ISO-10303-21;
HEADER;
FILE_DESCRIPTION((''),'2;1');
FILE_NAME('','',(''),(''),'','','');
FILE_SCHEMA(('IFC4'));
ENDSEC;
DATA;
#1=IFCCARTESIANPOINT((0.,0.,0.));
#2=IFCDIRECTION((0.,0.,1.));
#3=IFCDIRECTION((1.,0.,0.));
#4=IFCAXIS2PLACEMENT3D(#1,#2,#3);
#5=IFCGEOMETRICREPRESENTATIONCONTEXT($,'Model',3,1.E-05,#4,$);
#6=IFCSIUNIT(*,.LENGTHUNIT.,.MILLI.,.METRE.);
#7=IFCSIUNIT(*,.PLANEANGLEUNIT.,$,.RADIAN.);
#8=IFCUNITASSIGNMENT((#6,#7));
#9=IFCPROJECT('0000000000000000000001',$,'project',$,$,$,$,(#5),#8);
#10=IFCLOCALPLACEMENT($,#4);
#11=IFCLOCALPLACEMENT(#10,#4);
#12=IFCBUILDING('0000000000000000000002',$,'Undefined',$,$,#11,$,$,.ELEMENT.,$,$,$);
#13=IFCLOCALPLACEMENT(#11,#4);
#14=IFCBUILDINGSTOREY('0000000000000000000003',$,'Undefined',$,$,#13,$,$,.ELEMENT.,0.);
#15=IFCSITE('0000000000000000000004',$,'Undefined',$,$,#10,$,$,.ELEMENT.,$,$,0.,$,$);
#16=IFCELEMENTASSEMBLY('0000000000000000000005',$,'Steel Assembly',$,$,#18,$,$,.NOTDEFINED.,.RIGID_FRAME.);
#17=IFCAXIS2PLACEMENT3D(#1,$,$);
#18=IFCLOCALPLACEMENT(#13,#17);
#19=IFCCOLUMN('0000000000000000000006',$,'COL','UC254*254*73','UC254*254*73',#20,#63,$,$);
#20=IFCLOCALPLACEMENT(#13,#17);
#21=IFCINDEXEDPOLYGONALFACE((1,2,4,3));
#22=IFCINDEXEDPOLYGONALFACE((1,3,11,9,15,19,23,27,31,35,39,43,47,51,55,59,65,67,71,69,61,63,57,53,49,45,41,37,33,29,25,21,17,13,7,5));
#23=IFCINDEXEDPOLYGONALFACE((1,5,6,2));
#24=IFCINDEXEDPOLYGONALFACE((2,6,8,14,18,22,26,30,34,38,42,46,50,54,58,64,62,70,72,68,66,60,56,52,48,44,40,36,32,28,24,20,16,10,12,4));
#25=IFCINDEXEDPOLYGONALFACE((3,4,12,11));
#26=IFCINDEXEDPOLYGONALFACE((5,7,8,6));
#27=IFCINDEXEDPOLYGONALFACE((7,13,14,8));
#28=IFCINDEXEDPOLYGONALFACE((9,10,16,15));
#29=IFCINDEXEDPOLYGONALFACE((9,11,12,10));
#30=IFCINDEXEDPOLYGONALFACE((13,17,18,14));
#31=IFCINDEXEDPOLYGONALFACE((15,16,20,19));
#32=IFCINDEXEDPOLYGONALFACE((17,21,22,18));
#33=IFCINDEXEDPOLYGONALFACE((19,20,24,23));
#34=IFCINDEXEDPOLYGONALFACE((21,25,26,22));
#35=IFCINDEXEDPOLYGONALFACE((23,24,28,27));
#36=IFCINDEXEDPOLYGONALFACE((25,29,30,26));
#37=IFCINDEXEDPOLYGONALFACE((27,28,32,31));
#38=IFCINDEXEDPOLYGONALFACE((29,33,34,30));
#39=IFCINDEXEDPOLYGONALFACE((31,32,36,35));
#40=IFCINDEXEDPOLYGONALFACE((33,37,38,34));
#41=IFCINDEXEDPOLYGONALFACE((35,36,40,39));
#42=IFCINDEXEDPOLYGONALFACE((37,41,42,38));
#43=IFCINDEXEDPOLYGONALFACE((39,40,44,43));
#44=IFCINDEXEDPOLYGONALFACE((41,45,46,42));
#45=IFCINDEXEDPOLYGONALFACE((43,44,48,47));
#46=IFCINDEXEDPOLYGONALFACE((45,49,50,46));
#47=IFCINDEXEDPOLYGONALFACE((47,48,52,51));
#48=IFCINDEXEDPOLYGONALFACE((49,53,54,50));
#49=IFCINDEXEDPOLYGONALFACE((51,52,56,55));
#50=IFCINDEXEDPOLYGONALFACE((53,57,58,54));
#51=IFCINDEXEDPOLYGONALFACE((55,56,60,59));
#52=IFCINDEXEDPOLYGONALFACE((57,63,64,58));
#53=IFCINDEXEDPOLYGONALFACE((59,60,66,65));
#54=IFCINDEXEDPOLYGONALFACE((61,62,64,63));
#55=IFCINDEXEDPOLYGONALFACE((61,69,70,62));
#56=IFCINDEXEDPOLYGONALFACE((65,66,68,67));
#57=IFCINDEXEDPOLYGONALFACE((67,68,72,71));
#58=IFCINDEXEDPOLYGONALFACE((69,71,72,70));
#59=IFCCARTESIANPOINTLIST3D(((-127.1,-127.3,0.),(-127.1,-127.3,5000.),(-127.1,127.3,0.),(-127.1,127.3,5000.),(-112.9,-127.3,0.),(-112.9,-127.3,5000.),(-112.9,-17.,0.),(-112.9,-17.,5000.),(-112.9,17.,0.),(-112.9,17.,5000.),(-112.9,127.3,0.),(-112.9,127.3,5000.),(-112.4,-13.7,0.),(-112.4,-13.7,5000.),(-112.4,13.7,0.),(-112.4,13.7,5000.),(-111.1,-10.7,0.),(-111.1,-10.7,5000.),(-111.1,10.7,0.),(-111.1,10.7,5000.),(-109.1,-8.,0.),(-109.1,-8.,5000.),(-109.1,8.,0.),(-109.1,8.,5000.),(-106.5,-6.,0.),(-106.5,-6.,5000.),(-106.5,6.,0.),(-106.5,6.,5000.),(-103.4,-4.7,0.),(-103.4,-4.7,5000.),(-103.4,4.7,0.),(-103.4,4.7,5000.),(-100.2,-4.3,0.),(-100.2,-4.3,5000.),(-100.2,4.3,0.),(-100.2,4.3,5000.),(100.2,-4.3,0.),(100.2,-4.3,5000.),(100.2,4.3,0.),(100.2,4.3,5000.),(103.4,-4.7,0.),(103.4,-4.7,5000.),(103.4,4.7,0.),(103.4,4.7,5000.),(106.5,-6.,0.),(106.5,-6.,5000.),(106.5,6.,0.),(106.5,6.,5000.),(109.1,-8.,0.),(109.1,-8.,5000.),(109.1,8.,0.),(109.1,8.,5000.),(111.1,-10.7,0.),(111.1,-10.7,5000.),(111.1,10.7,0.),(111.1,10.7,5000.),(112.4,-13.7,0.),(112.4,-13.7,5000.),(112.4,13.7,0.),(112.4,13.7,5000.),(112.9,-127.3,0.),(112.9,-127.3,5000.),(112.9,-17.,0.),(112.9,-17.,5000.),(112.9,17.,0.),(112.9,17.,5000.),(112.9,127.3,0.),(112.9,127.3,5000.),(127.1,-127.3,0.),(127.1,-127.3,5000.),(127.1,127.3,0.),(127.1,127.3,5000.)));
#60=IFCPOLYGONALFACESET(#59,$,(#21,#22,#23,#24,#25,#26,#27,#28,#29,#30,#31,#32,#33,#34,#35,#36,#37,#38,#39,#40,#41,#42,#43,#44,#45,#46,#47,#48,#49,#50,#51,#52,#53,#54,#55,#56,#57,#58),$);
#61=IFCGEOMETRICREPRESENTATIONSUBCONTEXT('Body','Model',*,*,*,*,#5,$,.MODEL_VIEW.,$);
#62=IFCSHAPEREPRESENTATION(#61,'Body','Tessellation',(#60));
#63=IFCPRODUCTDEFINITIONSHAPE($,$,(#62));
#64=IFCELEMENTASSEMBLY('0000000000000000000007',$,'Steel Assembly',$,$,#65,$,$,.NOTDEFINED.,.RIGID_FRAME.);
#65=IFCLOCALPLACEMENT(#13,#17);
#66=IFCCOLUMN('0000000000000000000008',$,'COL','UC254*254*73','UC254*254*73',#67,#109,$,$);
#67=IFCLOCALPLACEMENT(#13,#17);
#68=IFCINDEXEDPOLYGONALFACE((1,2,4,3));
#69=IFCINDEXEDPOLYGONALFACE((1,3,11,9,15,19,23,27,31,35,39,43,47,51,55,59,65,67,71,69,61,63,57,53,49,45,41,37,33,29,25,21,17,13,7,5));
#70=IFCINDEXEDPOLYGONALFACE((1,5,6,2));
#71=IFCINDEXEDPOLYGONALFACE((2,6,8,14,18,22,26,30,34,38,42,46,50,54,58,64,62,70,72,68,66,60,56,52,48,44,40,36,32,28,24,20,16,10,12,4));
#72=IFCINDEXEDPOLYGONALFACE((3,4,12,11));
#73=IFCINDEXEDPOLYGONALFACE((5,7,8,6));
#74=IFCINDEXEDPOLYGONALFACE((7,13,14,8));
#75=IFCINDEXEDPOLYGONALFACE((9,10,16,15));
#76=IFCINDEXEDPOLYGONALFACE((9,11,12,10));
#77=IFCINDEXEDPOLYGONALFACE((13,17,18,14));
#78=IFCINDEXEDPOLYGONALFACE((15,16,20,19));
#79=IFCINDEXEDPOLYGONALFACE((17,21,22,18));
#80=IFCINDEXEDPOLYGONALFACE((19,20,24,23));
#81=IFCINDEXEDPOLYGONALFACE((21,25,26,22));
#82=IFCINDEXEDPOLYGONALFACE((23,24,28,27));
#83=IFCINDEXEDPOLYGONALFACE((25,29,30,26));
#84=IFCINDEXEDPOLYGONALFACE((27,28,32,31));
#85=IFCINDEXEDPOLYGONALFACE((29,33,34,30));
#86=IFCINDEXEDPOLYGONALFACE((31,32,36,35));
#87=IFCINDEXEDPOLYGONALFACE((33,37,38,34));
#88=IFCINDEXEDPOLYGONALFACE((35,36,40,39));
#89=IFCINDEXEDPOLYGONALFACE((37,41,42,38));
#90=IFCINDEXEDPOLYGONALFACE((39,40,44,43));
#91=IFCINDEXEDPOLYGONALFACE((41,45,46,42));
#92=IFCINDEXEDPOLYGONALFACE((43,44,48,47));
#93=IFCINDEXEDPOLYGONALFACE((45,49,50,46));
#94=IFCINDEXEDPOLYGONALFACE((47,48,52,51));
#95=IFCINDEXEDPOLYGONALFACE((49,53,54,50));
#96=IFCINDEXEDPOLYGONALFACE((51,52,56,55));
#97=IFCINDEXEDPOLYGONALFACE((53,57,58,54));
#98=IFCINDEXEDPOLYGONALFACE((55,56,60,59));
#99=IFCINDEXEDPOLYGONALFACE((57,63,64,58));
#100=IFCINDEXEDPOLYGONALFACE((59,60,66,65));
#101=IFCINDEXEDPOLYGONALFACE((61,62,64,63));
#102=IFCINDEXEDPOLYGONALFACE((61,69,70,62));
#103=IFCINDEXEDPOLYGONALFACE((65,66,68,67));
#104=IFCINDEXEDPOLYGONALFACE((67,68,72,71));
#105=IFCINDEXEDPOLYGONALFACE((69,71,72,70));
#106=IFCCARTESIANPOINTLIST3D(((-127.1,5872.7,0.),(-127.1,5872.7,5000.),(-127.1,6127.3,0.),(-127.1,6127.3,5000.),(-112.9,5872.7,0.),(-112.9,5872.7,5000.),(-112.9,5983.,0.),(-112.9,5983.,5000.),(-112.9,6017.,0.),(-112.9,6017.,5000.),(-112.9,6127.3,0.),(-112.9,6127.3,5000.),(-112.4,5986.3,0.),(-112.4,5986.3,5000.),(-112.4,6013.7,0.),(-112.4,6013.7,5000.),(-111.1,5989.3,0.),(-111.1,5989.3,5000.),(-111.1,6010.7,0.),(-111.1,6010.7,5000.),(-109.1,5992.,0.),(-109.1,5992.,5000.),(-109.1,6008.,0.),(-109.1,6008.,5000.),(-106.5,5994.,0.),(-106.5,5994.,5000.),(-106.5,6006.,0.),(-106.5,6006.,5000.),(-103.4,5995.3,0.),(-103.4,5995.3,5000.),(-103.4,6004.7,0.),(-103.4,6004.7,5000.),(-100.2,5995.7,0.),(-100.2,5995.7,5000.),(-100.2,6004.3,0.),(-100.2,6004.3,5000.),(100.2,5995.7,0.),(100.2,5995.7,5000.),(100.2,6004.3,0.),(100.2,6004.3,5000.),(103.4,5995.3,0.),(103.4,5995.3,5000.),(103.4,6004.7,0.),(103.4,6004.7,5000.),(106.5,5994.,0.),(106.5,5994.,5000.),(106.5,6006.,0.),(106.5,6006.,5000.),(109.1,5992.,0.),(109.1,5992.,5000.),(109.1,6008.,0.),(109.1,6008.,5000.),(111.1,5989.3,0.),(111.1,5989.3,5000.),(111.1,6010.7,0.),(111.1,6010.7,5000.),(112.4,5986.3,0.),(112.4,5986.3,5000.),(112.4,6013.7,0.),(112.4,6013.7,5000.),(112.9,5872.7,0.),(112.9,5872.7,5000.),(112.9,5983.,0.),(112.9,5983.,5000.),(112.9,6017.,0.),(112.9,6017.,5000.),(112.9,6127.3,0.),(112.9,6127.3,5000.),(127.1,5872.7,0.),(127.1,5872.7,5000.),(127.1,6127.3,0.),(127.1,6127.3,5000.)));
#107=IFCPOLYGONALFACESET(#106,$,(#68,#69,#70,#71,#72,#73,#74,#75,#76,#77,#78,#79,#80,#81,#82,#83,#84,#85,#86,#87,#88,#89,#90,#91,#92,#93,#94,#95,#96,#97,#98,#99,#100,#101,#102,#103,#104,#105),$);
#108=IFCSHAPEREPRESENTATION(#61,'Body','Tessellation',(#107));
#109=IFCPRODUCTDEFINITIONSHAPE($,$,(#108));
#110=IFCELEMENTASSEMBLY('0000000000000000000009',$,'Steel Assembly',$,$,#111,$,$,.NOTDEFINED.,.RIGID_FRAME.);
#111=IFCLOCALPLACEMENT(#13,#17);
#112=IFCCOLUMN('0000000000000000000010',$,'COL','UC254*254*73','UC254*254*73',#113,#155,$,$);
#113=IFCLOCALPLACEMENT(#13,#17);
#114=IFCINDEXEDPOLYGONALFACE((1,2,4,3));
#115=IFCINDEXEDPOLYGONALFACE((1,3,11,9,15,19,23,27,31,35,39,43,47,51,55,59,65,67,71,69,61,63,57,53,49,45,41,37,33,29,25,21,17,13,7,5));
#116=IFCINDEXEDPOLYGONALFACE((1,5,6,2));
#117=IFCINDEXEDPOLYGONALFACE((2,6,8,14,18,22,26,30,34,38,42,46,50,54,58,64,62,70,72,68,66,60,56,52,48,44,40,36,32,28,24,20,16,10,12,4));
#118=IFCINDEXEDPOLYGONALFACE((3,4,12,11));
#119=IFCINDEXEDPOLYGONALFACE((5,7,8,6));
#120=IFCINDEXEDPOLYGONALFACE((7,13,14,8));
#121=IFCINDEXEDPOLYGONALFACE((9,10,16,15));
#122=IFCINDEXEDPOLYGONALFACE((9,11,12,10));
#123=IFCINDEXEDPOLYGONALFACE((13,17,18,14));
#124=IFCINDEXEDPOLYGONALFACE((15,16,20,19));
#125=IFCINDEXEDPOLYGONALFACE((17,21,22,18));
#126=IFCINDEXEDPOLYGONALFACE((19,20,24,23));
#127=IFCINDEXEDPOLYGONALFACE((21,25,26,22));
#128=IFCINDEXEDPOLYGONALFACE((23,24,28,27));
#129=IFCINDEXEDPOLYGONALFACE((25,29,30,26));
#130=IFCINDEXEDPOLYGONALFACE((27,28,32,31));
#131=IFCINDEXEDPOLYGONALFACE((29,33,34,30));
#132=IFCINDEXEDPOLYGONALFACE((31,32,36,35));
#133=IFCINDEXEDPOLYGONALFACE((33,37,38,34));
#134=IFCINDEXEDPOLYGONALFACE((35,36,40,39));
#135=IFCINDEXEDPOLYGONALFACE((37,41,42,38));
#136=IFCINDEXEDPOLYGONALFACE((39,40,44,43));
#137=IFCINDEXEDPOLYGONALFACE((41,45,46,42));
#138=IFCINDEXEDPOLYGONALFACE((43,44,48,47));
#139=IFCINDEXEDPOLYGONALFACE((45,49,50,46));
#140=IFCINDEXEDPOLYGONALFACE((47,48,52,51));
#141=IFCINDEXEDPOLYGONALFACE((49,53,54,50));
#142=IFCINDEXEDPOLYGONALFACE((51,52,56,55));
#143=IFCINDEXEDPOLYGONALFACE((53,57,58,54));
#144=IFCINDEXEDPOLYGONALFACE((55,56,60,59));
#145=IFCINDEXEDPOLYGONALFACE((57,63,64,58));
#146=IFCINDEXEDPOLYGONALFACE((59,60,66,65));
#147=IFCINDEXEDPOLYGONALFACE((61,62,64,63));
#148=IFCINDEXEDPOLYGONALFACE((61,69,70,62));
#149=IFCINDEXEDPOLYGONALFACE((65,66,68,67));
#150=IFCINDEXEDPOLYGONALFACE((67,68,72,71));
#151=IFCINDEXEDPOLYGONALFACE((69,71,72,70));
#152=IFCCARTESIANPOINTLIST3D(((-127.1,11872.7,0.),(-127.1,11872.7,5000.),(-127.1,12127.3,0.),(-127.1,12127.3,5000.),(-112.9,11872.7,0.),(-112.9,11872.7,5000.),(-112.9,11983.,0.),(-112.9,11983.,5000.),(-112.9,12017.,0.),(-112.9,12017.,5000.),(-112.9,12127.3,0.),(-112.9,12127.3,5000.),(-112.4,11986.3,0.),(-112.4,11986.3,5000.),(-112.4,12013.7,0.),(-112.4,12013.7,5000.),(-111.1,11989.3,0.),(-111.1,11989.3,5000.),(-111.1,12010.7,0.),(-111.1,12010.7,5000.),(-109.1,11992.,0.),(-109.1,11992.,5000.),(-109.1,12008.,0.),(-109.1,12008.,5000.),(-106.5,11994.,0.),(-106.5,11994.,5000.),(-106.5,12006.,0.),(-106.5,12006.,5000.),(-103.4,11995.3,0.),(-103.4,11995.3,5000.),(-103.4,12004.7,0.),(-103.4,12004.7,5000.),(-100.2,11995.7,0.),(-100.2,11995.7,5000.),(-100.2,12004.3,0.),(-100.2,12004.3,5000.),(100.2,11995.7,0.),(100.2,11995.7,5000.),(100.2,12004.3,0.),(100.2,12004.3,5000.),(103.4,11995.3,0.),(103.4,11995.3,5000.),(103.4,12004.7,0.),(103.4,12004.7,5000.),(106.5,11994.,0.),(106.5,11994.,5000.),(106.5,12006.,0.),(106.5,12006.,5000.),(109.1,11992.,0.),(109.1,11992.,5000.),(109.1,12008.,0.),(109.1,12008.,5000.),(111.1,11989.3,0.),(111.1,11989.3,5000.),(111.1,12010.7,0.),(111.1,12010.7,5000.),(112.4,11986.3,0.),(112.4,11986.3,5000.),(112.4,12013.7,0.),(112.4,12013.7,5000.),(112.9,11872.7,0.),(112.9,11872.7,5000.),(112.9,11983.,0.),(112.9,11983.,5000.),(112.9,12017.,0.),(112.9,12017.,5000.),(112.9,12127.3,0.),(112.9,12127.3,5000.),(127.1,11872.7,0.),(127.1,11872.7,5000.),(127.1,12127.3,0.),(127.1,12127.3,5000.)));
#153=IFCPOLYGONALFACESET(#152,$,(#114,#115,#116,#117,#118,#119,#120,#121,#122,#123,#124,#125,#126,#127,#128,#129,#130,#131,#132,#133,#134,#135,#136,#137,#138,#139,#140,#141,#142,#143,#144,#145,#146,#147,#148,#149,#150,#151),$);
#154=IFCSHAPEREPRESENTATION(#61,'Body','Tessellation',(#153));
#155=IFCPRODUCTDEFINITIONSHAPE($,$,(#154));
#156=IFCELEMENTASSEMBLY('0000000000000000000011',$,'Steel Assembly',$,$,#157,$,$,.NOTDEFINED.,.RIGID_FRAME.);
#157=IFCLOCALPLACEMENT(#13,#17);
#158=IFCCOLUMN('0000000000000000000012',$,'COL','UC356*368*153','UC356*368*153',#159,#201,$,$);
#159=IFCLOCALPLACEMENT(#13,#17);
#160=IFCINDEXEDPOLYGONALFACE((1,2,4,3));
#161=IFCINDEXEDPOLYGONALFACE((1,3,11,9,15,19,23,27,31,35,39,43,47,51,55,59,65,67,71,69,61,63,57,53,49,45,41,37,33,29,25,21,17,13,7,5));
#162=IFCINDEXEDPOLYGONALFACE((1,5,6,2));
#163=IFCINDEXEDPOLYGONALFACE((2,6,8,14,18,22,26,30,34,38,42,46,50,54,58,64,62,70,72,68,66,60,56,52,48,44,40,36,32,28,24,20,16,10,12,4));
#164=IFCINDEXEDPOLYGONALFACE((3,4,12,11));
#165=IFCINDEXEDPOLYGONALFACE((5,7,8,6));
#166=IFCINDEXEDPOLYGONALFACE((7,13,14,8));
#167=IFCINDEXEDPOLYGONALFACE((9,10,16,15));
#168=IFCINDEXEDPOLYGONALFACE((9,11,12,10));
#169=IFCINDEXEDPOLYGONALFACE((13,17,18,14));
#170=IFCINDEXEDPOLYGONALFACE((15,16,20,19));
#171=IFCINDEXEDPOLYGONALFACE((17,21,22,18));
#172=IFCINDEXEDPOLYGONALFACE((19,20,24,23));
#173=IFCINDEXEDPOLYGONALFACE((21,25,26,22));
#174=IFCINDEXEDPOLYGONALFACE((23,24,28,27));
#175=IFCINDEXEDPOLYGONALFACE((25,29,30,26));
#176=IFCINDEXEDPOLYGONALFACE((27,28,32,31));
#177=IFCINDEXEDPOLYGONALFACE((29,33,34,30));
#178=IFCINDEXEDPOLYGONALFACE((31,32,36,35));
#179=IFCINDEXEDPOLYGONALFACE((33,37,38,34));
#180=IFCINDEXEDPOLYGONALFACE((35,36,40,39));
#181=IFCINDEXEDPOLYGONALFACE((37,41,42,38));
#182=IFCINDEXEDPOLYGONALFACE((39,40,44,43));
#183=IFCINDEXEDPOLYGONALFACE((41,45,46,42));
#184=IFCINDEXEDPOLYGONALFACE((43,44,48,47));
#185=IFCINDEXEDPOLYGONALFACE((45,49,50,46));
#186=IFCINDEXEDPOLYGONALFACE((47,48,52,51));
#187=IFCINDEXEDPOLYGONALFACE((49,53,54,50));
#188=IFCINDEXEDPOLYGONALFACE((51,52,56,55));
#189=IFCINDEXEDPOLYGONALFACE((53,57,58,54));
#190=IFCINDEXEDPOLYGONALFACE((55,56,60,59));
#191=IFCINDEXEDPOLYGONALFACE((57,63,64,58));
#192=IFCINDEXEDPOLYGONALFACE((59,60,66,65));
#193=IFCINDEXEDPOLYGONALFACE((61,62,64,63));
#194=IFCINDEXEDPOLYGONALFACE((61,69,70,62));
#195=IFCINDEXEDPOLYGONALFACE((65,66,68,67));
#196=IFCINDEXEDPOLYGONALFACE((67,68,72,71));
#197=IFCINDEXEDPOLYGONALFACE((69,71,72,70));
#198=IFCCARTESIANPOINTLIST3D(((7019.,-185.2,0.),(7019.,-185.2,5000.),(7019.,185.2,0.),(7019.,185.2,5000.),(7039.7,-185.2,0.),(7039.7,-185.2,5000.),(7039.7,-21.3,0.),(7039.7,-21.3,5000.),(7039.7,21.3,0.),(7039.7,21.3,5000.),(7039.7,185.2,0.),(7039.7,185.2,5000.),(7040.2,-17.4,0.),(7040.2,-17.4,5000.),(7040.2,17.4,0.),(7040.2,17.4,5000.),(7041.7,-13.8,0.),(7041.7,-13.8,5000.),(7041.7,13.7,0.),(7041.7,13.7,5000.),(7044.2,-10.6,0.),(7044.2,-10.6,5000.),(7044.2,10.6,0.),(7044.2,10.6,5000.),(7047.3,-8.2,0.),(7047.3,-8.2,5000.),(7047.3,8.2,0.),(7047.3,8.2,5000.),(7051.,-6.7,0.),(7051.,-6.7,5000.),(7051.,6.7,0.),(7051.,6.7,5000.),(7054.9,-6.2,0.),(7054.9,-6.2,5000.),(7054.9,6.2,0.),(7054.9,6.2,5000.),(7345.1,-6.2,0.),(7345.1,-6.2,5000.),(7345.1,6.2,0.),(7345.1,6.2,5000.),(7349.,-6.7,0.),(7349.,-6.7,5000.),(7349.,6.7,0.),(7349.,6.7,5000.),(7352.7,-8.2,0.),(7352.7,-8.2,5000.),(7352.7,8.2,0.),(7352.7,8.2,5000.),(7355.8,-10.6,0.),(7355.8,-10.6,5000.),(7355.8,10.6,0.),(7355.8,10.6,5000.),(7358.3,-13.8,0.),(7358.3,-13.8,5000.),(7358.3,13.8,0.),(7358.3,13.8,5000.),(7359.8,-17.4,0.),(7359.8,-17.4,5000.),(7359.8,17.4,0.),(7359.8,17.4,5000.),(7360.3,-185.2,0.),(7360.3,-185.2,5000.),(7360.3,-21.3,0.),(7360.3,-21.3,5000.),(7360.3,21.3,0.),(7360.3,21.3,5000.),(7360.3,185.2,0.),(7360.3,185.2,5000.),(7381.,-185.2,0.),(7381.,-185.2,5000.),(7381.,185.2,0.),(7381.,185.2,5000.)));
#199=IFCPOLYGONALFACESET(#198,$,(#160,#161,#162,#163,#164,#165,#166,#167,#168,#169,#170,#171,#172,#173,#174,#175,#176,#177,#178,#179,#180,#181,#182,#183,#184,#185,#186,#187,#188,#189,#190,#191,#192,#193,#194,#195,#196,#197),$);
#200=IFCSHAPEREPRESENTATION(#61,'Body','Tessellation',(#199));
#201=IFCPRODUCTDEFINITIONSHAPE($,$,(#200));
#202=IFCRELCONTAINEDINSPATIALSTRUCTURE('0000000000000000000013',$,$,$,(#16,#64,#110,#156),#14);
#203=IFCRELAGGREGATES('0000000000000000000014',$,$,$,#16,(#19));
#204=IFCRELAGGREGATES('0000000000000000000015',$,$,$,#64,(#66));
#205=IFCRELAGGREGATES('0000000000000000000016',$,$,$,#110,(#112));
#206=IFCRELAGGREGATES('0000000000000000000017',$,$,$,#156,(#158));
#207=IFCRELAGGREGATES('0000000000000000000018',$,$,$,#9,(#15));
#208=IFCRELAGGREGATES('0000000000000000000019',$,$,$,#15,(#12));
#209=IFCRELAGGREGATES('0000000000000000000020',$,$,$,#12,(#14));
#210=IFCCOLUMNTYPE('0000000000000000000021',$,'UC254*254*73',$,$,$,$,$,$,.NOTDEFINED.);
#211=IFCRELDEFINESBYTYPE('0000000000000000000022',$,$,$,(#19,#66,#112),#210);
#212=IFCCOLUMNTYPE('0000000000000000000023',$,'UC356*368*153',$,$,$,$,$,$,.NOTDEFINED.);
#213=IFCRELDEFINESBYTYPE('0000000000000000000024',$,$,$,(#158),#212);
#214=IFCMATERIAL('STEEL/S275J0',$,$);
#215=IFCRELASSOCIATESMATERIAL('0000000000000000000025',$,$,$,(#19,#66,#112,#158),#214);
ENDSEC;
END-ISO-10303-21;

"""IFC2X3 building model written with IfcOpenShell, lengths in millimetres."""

from ifc_helpers import new_model, si_unit, frame, origin_with_axes, origin_2d_with_axis, place, context, subcontext, project, spatial, i_section, extrude, material, type_object, element, aggregate, save


model = new_model("IFC2X3")

# Units and contexts
model_context = context("Model", 3, precision=1e-05, world=origin_with_axes())
body_context = subcontext(model_context, "Body", "Model", "MODEL_VIEW")
ifc_project = project(units=[si_unit("LENGTHUNIT", "METRE", prefix="MILLI"), si_unit("PLANEANGLEUNIT", "RADIAN")], contexts=[model_context])

# Site, building, storey
site_placement = place(None, origin_with_axes())
site = spatial("IfcSite", under=ifc_project, at=site_placement, Name="Undefined", CompositionType="ELEMENT", RefElevation=0.0)
building_placement = place(site_placement, origin_with_axes())
building = spatial("IfcBuilding", under=site, at=building_placement, Name="Undefined", CompositionType="ELEMENT")
storey_placement = place(building_placement, origin_with_axes())
storey = spatial("IfcBuildingStorey", under=building, at=storey_placement, Name="Undefined", CompositionType="ELEMENT", Elevation=0.0)

# Element assemblies, columns
assembly_1_placement = place(storey_placement, origin_with_axes())
assembly_1 = element("IfcElementAssembly", 1, at=assembly_1_placement, inside=storey, Name="Steel Assembly", AssemblyPlace="NOTDEFINED", PredefinedType="RIGID_FRAME")
ifc_material = material(Name="STEEL/S275J0")
column_type_1 = type_object("IfcColumnType", Name="UC254*254*73", PredefinedType="NOTDEFINED")
column_1_placement = place(assembly_1_placement, origin_with_axes())
column_1 = element("IfcColumn", 2, at=column_1_placement, type_object=column_type_1, material=ifc_material, Name="COL", Description="UC254*254*73", ObjectType="UC254*254*73", context=body_context, shape_type="SweptSolid", body=[
    extrude(i_section(OverallWidth=254.6, OverallDepth=254.1, WebThickness=8.6, FlangeThickness=14.2, FilletRadius=12.7, at=origin_2d_with_axis()), frame((0.0, 0.0, 5000.0), z_axis=(0.0, 0.0, -1.0), x_axis=(0.0, -1.0, 0.0)), (0.0, 0.0, 1.0), 5000.0),
])
aggregate(assembly_1, [column_1])
assembly_2_placement = place(storey_placement, origin_with_axes())
assembly_2 = element("IfcElementAssembly", 3, at=assembly_2_placement, inside=storey, Name="Steel Assembly", AssemblyPlace="NOTDEFINED", PredefinedType="RIGID_FRAME")
column_2_placement = place(assembly_2_placement, frame((0.0, 6000.0, 0.0), z_axis=(0.0, 0.0, 1.0), x_axis=(1.0, 0.0, 0.0)))
column_2 = element("IfcColumn", 4, at=column_2_placement, type_object=column_type_1, material=ifc_material, Name="COL", Description="UC254*254*73", ObjectType="UC254*254*73", context=body_context, shape_type="SweptSolid", body=[
    extrude(i_section(OverallWidth=254.6, OverallDepth=254.1, WebThickness=8.6, FlangeThickness=14.2, FilletRadius=12.7, at=origin_2d_with_axis()), frame((0.0, 0.0, 5000.0), z_axis=(0.0, 0.0, -1.0), x_axis=(0.0, -1.0, 0.0)), (0.0, 0.0, 1.0), 5000.0),
])
aggregate(assembly_2, [column_2])
assembly_3_placement = place(storey_placement, origin_with_axes())
assembly_3 = element("IfcElementAssembly", 5, at=assembly_3_placement, inside=storey, Name="Steel Assembly", AssemblyPlace="NOTDEFINED", PredefinedType="RIGID_FRAME")
column_3_placement = place(assembly_3_placement, frame((0.0, 12000.0, 0.0), z_axis=(0.0, 0.0, 1.0), x_axis=(1.0, 0.0, 0.0)))
column_3 = element("IfcColumn", 6, at=column_3_placement, type_object=column_type_1, material=ifc_material, Name="COL", Description="UC254*254*73", ObjectType="UC254*254*73", context=body_context, shape_type="SweptSolid", body=[
    extrude(i_section(OverallWidth=254.6, OverallDepth=254.1, WebThickness=8.6, FlangeThickness=14.2, FilletRadius=12.7, at=origin_2d_with_axis()), frame((0.0, 0.0, 5000.0), z_axis=(0.0, 0.0, -1.0), x_axis=(0.0, -1.0, 0.0)), (0.0, 0.0, 1.0), 5000.0),
])
aggregate(assembly_3, [column_3])
assembly_4_placement = place(storey_placement, origin_with_axes())
assembly_4 = element("IfcElementAssembly", 7, at=assembly_4_placement, inside=storey, Name="Steel Assembly", AssemblyPlace="NOTDEFINED", PredefinedType="RIGID_FRAME")
column_type_2 = type_object("IfcColumnType", Name="UC356*368*153", PredefinedType="NOTDEFINED")
column_4_placement = place(assembly_4_placement, frame((7200.0, 0.0, 0.0), z_axis=(0.0, 0.0, 1.0), x_axis=(1.0, 0.0, 0.0)))
column_4 = element("IfcColumn", 8, at=column_4_placement, type_object=column_type_2, material=ifc_material, Name="COL", Description="UC356*368*153", ObjectType="UC356*368*153", context=body_context, shape_type="SweptSolid", body=[
    extrude(i_section(OverallWidth=370.5, OverallDepth=362.0, WebThickness=12.3, FlangeThickness=20.7, FilletRadius=15.2, at=origin_2d_with_axis()), frame((0.0, 0.0, 5000.0), z_axis=(0.0, 0.0, -1.0), x_axis=(0.0, -1.0, 0.0)), (0.0, 0.0, 1.0), 5000.0),
])
aggregate(assembly_4, [column_4])

save(model, "model.ifc")
